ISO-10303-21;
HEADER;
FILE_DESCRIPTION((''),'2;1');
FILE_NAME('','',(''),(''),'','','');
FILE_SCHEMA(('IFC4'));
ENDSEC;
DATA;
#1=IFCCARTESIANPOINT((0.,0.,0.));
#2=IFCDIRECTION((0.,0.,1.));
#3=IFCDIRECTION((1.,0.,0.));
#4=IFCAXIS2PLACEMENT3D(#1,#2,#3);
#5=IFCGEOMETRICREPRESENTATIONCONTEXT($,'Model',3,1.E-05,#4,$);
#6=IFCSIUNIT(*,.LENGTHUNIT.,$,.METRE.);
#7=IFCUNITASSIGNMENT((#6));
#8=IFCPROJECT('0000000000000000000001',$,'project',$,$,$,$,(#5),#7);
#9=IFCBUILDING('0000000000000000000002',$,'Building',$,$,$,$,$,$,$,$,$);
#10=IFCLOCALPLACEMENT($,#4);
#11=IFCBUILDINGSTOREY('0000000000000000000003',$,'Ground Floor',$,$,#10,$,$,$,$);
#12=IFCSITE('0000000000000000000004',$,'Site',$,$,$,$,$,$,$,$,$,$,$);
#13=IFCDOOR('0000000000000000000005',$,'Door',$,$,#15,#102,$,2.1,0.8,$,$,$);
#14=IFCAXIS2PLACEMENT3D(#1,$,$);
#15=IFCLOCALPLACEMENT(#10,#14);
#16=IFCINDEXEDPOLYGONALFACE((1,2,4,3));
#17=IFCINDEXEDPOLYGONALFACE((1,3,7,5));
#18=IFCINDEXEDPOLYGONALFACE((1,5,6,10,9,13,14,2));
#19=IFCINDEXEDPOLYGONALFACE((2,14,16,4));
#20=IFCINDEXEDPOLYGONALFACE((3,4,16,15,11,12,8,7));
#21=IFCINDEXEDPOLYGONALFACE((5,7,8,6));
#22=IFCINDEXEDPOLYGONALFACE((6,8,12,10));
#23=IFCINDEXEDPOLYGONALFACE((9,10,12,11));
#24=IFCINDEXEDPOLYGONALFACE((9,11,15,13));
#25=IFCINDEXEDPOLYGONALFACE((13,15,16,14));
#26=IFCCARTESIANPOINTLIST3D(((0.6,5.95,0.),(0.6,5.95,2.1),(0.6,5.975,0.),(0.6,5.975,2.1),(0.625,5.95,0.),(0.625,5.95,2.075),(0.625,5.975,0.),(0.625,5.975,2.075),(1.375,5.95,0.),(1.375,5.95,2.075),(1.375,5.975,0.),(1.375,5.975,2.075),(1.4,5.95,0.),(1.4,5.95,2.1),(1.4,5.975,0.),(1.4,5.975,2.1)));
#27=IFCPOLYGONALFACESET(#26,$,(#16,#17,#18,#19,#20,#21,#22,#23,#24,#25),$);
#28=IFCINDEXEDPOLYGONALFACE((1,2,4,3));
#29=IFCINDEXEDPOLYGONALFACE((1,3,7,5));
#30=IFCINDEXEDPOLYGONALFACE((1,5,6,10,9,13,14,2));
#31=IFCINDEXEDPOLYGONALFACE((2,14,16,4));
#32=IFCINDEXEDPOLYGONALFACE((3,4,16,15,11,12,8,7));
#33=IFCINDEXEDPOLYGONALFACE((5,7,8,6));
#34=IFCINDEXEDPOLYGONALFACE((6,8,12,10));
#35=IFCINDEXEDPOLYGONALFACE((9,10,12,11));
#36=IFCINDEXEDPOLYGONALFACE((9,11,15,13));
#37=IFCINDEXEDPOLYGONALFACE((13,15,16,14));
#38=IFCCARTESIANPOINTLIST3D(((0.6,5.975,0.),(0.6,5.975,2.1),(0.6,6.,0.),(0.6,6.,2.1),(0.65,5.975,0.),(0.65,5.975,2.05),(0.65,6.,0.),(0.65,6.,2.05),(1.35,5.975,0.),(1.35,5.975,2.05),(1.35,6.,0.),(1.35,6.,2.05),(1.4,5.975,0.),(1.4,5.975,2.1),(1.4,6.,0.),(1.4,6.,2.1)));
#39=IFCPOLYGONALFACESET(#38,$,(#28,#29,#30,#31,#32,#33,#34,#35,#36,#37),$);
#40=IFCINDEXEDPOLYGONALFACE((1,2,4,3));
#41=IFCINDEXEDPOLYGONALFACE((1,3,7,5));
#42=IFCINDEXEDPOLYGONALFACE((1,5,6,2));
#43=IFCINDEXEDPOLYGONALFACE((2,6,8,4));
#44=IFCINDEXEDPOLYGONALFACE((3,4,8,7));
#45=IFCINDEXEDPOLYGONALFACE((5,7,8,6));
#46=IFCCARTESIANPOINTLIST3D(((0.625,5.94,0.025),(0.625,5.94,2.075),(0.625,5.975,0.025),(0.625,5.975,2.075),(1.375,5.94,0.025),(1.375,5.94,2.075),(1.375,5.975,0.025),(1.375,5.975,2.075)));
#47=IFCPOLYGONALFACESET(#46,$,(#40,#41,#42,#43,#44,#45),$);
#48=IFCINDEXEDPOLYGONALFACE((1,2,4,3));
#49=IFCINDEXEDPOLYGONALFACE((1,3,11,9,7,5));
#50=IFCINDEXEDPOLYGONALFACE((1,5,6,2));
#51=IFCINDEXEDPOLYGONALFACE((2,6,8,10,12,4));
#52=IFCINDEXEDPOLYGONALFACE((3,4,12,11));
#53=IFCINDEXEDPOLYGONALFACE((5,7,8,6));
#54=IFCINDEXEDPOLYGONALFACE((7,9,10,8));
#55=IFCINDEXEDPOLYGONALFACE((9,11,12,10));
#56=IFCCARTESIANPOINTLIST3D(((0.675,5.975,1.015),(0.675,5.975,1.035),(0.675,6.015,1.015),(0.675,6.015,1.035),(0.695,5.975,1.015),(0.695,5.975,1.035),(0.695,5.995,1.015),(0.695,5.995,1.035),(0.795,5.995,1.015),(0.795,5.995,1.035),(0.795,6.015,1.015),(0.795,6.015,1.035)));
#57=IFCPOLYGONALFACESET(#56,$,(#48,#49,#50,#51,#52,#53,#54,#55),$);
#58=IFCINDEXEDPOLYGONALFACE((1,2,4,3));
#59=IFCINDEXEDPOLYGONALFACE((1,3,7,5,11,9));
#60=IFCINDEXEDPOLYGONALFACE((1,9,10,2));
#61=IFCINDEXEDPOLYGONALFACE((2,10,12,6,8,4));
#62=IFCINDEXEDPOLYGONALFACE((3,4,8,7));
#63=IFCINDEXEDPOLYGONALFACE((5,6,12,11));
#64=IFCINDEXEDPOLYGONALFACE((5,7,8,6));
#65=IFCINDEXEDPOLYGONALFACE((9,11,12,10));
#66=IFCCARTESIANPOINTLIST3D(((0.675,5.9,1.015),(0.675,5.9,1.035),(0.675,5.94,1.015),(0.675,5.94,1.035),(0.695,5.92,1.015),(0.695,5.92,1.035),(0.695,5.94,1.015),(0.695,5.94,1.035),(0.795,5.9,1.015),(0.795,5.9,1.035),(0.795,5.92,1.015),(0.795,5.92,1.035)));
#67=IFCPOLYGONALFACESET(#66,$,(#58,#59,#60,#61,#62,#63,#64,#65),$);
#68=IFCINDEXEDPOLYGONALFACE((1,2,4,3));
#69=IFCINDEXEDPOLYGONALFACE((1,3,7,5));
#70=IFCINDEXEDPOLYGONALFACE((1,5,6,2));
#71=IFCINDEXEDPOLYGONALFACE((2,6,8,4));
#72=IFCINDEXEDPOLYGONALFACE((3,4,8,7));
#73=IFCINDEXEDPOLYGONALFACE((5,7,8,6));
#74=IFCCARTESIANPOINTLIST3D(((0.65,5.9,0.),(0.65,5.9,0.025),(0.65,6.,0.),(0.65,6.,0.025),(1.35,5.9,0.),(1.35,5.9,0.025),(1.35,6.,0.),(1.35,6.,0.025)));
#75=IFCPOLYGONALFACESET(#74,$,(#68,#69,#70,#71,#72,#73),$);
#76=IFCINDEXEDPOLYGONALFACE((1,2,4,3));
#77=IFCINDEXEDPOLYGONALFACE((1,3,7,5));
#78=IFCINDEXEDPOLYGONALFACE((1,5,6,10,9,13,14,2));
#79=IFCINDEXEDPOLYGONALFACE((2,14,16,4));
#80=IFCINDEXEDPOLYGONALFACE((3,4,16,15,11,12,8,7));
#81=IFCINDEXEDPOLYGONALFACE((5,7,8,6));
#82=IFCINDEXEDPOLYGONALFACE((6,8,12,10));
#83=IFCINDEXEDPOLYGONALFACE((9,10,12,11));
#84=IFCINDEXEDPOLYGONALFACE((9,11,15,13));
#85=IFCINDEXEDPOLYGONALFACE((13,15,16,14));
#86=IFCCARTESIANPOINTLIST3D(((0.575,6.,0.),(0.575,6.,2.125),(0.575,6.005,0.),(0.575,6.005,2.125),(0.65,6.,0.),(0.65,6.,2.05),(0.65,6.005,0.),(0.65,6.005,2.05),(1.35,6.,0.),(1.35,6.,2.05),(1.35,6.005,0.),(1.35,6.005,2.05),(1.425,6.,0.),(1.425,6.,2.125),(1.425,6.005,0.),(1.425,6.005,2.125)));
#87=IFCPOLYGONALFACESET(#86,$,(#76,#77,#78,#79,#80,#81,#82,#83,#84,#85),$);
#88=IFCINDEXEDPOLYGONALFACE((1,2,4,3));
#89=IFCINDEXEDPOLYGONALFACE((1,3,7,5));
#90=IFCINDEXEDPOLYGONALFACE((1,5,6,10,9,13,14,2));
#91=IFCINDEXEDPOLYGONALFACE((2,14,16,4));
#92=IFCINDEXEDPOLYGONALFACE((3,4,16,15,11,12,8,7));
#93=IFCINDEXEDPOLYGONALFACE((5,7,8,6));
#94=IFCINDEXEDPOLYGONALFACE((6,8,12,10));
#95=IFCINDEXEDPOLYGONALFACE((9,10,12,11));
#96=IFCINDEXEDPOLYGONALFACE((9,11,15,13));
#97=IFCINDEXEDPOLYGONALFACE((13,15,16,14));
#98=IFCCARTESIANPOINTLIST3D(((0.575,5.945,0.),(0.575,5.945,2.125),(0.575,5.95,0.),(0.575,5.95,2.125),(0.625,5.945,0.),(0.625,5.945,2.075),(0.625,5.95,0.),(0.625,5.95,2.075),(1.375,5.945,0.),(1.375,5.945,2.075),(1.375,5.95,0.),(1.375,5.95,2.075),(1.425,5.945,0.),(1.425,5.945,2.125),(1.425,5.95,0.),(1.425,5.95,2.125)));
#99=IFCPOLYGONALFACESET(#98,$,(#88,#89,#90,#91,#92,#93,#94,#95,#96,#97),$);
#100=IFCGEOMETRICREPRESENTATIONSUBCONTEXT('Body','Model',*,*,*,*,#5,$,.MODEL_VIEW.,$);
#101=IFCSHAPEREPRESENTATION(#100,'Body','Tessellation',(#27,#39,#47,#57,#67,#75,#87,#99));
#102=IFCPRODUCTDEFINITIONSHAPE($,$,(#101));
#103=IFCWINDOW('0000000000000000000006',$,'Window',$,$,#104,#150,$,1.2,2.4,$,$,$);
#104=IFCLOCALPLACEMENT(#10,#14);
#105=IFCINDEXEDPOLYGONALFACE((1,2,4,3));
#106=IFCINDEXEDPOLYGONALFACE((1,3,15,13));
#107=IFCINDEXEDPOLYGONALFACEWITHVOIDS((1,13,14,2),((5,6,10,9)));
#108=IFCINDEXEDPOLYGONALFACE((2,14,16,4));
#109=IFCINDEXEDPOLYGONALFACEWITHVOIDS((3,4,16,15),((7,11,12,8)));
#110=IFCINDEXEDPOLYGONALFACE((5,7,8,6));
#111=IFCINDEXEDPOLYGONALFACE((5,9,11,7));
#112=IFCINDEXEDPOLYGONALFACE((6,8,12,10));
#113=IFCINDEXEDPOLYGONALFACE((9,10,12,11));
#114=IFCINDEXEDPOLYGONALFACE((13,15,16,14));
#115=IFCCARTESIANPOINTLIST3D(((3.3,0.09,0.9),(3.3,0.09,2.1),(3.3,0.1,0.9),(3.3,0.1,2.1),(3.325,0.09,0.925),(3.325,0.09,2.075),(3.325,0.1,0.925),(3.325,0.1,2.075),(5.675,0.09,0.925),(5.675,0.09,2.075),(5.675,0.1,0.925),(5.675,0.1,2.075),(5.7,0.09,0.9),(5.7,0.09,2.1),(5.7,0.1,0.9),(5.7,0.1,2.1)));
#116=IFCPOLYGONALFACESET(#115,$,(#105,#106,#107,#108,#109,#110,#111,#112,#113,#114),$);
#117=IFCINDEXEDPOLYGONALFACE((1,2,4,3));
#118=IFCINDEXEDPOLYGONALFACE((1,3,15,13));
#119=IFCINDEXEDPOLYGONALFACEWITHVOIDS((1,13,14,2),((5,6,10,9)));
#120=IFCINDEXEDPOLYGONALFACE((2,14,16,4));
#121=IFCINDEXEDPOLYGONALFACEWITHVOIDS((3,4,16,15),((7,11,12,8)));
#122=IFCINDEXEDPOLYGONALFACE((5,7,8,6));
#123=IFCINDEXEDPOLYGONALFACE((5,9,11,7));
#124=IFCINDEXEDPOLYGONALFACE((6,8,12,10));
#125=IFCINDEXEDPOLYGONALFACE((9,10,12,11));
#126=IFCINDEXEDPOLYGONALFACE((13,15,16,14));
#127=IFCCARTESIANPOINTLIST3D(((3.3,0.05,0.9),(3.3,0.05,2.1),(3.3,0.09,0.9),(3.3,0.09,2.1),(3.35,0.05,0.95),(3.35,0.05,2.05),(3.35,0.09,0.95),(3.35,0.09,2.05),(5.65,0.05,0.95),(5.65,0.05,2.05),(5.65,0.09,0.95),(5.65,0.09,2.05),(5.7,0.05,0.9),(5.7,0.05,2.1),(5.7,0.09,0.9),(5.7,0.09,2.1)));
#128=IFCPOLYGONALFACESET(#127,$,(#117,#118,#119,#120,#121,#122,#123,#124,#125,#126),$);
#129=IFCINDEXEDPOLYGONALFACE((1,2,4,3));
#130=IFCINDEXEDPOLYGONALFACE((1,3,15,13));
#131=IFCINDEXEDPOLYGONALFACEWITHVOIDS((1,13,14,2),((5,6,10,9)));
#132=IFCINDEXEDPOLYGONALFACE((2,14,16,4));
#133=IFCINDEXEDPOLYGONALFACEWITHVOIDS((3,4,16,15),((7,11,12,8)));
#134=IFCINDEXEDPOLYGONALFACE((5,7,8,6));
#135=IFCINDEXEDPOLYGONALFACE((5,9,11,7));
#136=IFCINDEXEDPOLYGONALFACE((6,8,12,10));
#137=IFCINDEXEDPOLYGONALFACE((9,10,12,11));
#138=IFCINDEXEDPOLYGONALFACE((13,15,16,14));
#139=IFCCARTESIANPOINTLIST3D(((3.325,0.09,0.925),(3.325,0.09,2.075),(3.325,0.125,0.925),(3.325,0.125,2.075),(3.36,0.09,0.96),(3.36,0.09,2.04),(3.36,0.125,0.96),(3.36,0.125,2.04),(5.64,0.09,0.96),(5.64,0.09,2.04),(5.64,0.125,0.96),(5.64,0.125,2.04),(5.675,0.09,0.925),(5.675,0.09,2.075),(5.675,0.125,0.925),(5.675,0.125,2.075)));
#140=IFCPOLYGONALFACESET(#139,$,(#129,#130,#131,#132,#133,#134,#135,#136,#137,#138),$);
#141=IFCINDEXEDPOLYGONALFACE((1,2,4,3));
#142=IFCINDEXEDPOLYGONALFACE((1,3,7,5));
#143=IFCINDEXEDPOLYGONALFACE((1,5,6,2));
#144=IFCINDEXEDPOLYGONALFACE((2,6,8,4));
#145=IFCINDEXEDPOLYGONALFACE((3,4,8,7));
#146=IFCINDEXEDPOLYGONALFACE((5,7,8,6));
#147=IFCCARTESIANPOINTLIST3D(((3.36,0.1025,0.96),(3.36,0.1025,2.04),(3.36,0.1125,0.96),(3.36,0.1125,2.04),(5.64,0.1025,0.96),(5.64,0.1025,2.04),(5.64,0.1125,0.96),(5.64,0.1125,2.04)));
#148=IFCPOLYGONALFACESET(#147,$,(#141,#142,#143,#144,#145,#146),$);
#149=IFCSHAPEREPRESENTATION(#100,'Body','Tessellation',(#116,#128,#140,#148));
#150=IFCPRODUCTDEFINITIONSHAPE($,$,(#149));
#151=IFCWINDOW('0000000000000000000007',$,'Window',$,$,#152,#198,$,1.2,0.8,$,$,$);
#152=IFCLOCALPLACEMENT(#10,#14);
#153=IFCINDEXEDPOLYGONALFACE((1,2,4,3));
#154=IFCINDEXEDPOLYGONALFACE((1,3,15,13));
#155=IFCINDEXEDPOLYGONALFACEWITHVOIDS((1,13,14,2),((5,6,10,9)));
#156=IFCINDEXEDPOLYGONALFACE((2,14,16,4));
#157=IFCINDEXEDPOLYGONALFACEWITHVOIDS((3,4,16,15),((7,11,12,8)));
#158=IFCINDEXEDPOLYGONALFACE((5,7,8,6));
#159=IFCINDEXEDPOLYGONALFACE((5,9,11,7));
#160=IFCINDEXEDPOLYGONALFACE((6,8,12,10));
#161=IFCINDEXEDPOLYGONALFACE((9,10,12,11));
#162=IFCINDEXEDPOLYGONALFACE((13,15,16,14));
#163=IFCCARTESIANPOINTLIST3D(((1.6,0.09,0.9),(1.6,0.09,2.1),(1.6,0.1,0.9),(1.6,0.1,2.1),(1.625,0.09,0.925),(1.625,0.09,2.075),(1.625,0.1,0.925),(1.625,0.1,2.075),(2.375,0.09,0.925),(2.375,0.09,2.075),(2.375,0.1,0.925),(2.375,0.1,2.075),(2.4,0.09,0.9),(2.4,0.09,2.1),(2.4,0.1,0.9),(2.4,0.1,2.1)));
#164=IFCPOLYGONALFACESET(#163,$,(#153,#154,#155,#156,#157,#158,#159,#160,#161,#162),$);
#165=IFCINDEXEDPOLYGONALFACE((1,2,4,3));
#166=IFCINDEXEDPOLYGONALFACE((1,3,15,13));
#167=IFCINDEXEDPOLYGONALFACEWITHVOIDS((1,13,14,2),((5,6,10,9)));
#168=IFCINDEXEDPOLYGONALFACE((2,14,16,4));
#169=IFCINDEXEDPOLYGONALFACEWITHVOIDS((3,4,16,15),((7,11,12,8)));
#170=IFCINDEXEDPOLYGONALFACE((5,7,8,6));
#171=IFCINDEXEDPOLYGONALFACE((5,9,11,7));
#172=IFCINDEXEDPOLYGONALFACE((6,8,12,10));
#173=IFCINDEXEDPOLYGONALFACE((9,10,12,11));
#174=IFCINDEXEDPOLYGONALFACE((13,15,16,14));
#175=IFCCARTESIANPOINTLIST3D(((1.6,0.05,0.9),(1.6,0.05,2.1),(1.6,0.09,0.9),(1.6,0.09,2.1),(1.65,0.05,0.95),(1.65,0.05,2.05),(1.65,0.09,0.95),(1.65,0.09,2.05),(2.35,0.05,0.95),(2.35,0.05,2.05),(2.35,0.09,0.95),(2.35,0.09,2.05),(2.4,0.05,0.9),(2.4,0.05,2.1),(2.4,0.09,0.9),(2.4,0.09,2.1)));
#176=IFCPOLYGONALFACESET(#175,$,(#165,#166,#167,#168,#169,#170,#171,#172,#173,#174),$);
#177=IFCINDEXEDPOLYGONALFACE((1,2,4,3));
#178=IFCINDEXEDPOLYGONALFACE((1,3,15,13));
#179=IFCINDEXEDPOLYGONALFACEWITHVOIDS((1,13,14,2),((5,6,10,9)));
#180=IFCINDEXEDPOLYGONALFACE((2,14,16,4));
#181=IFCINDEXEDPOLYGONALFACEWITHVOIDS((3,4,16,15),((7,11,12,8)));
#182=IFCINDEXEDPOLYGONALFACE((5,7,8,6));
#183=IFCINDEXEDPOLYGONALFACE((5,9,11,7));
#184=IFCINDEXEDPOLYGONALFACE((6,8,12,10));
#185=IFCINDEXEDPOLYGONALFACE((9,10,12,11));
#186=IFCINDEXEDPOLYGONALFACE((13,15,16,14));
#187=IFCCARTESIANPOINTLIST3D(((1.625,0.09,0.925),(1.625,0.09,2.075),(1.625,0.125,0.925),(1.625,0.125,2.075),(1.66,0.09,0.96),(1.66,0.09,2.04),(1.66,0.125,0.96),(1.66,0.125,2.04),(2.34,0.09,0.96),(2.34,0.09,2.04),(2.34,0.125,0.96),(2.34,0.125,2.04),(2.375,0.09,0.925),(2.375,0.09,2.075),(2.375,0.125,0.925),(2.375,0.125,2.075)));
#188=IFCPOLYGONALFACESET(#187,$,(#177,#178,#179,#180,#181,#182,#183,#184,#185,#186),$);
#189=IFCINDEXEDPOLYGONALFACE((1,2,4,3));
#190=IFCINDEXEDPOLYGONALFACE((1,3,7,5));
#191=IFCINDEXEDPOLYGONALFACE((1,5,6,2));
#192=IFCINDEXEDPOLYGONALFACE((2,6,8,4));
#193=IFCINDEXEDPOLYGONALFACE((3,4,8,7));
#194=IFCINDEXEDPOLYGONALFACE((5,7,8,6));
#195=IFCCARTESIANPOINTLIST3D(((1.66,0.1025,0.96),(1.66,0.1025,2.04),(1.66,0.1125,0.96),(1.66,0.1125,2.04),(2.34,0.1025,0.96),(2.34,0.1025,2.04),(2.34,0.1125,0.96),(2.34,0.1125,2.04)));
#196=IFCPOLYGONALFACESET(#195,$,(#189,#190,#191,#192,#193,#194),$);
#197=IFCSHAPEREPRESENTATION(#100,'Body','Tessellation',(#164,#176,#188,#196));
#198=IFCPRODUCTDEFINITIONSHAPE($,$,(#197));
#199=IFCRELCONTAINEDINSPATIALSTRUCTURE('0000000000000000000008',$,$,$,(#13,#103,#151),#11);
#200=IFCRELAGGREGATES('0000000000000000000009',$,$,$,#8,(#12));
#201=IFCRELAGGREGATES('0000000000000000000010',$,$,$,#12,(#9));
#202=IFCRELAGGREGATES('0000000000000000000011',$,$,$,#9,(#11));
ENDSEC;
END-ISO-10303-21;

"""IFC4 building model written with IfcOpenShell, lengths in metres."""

from ifc_helpers import new_model, si_unit, frame, origin_with_axes, place, context, subcontext, project, spatial, line, indexed_curve, outline, extrude, element, save


model = new_model("IFC4")

# Units and contexts
model_context = context("Model", 3, precision=1e-05, world=origin_with_axes())
body_context = subcontext(model_context, "Body", "Model", "MODEL_VIEW")
ifc_project = project(units=[si_unit("LENGTHUNIT", "METRE")], contexts=[model_context])

# Site, building, storey
site = spatial("IfcSite", under=ifc_project, Name="Site")
building = spatial("IfcBuilding", under=site, Name="Building")
storey_placement = place(None, origin_with_axes())
storey = spatial("IfcBuildingStorey", under=building, at=storey_placement, Name="Ground Floor")

# Door
door_1_placement = place(storey_placement, frame((1.4, 6.0, 0.0), z_axis=(0.0, 0.0, 1.0), x_axis=(-1.0, 0.0, 0.0)))
element("IfcDoor", 1, at=door_1_placement, inside=storey, Name="Door", OverallHeight=2.1, OverallWidth=0.8, context=body_context, shape_type="SweptSolid", body=[
    extrude(outline(indexed_curve([(0.0, 0.0), (0.0, 2.1), (0.8, 2.1), (0.8, 0.0), (0.775, 0.0), (0.775, 2.075), (0.025, 2.075), (0.025, 0.0)], segments=[line(1, 2, 3, 4, 5, 6, 7, 8, 1)])), frame((0.0, 0.025, 0.0), z_axis=(0.0, -1.0, 0.0), x_axis=(1.0, 0.0, 0.0)), (0.0, 0.0, -1.0), 0.025),
    extrude(outline(indexed_curve([(0.0, 0.0), (0.0, 2.1), (0.8, 2.1), (0.8, 0.0), (0.75, 0.0), (0.75, 2.05), (0.05, 2.05), (0.05, 0.0)], segments=[line(1, 2, 3, 4, 5, 6, 7, 8, 1)])), frame((0.0, 0.0, 0.0), z_axis=(0.0, -1.0, 0.0), x_axis=(1.0, 0.0, 0.0)), (0.0, 0.0, -1.0), 0.025),
    extrude(outline(indexed_curve([(0.0, 0.0), (0.75, 0.0), (0.75, 0.035), (0.0, 0.035)], segments=[line(1, 2, 3, 4, 1)])), frame((0.025, 0.025, 0.025), z_axis=(0.0, 0.0, 1.0), x_axis=(1.0, 0.0, 0.0)), (0.0, 0.0, 1.0), 2.05),
    extrude(outline(indexed_curve([(0.0, 0.0), (0.0, -0.04), (-0.12, -0.04), (-0.12, -0.02), (-0.02, -0.02), (-0.02, 0.0)], segments=[line(1, 2, 3, 4, 5, 6, 1)])), frame((0.725, 0.025, 1.015), z_axis=(0.0, 0.0, 1.0), x_axis=(1.0, 0.0, 0.0)), (0.0, 0.0, 1.0), 0.02),
    extrude(outline(indexed_curve([(0.0, 0.0), (0.0, 0.04), (-0.12, 0.04), (-0.12, 0.02), (-0.02, 0.02), (-0.02, 0.0)], segments=[line(1, 2, 3, 4, 5, 6, 1)])), frame((0.725, 0.06, 1.015), z_axis=(0.0, 0.0, 1.0), x_axis=(1.0, 0.0, 0.0)), (0.0, 0.0, 1.0), 0.02),
    extrude(outline(indexed_curve([(0.0, 0.0), (0.7, 0.0), (0.7, 0.1), (0.0, 0.1)], segments=[line(1, 2, 3, 4, 1)])), frame((0.05, 0.0, 0.0), z_axis=(0.0, 0.0, 1.0), x_axis=(1.0, 0.0, 0.0)), (0.0, 0.0, 1.0), 0.025),
    extrude(outline(indexed_curve([(0.0, 0.0), (0.0, 2.125), (0.85, 2.125), (0.85, 0.0), (0.775, 0.0), (0.775, 2.05), (0.075, 2.05), (0.075, 0.0)], segments=[line(1, 2, 3, 4, 5, 6, 7, 8, 1)])), frame((-0.025, -0.005, 0.0), z_axis=(0.0, -1.0, 0.0), x_axis=(1.0, 0.0, 0.0)), (0.0, 0.0, -1.0), 0.005),
    extrude(outline(indexed_curve([(0.0, 0.0), (0.0, 2.125), (0.85, 2.125), (0.85, 0.0), (0.8, 0.0), (0.8, 2.075), (0.05, 2.075), (0.05, 0.0)], segments=[line(1, 2, 3, 4, 5, 6, 7, 8, 1)])), frame((-0.025, 0.05, 0.0), z_axis=(0.0, -1.0, 0.0), x_axis=(1.0, 0.0, 0.0)), (0.0, 0.0, -1.0), 0.005),
])

# Windows
window_1_placement = place(storey_placement, frame((3.3, 0.0, 0.9), z_axis=(0.0, 0.0, 1.0), x_axis=(1.0, 0.0, 0.0)))
element("IfcWindow", 2, at=window_1_placement, inside=storey, Name="Window", OverallHeight=1.2, OverallWidth=2.4, context=body_context, shape_type="SweptSolid", body=[
    extrude(outline(indexed_curve([(0.0, 0.0), (2.4, 0.0), (2.4, 1.2), (0.0, 1.2)], segments=[line(1, 2, 3, 4, 1)]), holes=[indexed_curve([(0.025, 0.025), (2.375, 0.025), (2.375, 1.175), (0.025, 1.175)], segments=[line(1, 2, 3, 4, 1)])]), frame((0.0, 0.09, 0.0), z_axis=(0.0, -1.0, 0.0), x_axis=(1.0, 0.0, 0.0)), (0.0, 0.0, -1.0), 0.01),
    extrude(outline(indexed_curve([(0.0, 0.0), (2.4, 0.0), (2.4, 1.2), (0.0, 1.2)], segments=[line(1, 2, 3, 4, 1)]), holes=[indexed_curve([(0.05, 0.05), (2.35, 0.05), (2.35, 1.15), (0.05, 1.15)], segments=[line(1, 2, 3, 4, 1)])]), frame((0.0, 0.05, 0.0), z_axis=(0.0, -1.0, 0.0), x_axis=(1.0, 0.0, 0.0)), (0.0, 0.0, -1.0), 0.04),
    extrude(outline(indexed_curve([(0.0, 0.0), (2.35, 0.0), (2.35, 1.15), (0.0, 1.15)], segments=[line(1, 2, 3, 4, 1)]), holes=[indexed_curve([(0.035, 0.035), (2.315, 0.035), (2.315, 1.115), (0.035, 1.115)], segments=[line(1, 2, 3, 4, 1)])]), frame((0.025, 0.09, 0.025), z_axis=(0.0, -1.0, 0.0), x_axis=(1.0, 0.0, 0.0)), (0.0, 0.0, -1.0), 0.035),
    extrude(outline(indexed_curve([(0.035, 0.035), (2.315, 0.035), (2.315, 1.115), (0.035, 1.115)], segments=[line(1, 2, 3, 4, 1)])), frame((0.025, 0.1025, 0.025), z_axis=(0.0, -1.0, 0.0), x_axis=(1.0, 0.0, 0.0)), (0.0, 0.0, -1.0), 0.01),
])
window_2_placement = place(storey_placement, frame((1.6, 0.0, 0.9), z_axis=(0.0, 0.0, 1.0), x_axis=(1.0, 0.0, 0.0)))
element("IfcWindow", 3, at=window_2_placement, inside=storey, Name="Window", OverallHeight=1.2, OverallWidth=0.8, context=body_context, shape_type="SweptSolid", body=[
    extrude(outline(indexed_curve([(0.0, 0.0), (0.8, 0.0), (0.8, 1.2), (0.0, 1.2)], segments=[line(1, 2, 3, 4, 1)]), holes=[indexed_curve([(0.025, 0.025), (0.775, 0.025), (0.775, 1.175), (0.025, 1.175)], segments=[line(1, 2, 3, 4, 1)])]), frame((0.0, 0.09, 0.0), z_axis=(0.0, -1.0, 0.0), x_axis=(1.0, 0.0, 0.0)), (0.0, 0.0, -1.0), 0.01),
    extrude(outline(indexed_curve([(0.0, 0.0), (0.8, 0.0), (0.8, 1.2), (0.0, 1.2)], segments=[line(1, 2, 3, 4, 1)]), holes=[indexed_curve([(0.05, 0.05), (0.75, 0.05), (0.75, 1.15), (0.05, 1.15)], segments=[line(1, 2, 3, 4, 1)])]), frame((0.0, 0.05, 0.0), z_axis=(0.0, -1.0, 0.0), x_axis=(1.0, 0.0, 0.0)), (0.0, 0.0, -1.0), 0.04),
    extrude(outline(indexed_curve([(0.0, 0.0), (0.75, 0.0), (0.75, 1.15), (0.0, 1.15)], segments=[line(1, 2, 3, 4, 1)]), holes=[indexed_curve([(0.035, 0.035), (0.715, 0.035), (0.715, 1.115), (0.035, 1.115)], segments=[line(1, 2, 3, 4, 1)])]), frame((0.025, 0.09, 0.025), z_axis=(0.0, -1.0, 0.0), x_axis=(1.0, 0.0, 0.0)), (0.0, 0.0, -1.0), 0.035),
    extrude(outline(indexed_curve([(0.035, 0.035), (0.715, 0.035), (0.715, 1.115), (0.035, 1.115)], segments=[line(1, 2, 3, 4, 1)])), frame((0.025, 0.1025, 0.025), z_axis=(0.0, -1.0, 0.0), x_axis=(1.0, 0.0, 0.0)), (0.0, 0.0, -1.0), 0.01),
])

save(model, "model.ifc")
